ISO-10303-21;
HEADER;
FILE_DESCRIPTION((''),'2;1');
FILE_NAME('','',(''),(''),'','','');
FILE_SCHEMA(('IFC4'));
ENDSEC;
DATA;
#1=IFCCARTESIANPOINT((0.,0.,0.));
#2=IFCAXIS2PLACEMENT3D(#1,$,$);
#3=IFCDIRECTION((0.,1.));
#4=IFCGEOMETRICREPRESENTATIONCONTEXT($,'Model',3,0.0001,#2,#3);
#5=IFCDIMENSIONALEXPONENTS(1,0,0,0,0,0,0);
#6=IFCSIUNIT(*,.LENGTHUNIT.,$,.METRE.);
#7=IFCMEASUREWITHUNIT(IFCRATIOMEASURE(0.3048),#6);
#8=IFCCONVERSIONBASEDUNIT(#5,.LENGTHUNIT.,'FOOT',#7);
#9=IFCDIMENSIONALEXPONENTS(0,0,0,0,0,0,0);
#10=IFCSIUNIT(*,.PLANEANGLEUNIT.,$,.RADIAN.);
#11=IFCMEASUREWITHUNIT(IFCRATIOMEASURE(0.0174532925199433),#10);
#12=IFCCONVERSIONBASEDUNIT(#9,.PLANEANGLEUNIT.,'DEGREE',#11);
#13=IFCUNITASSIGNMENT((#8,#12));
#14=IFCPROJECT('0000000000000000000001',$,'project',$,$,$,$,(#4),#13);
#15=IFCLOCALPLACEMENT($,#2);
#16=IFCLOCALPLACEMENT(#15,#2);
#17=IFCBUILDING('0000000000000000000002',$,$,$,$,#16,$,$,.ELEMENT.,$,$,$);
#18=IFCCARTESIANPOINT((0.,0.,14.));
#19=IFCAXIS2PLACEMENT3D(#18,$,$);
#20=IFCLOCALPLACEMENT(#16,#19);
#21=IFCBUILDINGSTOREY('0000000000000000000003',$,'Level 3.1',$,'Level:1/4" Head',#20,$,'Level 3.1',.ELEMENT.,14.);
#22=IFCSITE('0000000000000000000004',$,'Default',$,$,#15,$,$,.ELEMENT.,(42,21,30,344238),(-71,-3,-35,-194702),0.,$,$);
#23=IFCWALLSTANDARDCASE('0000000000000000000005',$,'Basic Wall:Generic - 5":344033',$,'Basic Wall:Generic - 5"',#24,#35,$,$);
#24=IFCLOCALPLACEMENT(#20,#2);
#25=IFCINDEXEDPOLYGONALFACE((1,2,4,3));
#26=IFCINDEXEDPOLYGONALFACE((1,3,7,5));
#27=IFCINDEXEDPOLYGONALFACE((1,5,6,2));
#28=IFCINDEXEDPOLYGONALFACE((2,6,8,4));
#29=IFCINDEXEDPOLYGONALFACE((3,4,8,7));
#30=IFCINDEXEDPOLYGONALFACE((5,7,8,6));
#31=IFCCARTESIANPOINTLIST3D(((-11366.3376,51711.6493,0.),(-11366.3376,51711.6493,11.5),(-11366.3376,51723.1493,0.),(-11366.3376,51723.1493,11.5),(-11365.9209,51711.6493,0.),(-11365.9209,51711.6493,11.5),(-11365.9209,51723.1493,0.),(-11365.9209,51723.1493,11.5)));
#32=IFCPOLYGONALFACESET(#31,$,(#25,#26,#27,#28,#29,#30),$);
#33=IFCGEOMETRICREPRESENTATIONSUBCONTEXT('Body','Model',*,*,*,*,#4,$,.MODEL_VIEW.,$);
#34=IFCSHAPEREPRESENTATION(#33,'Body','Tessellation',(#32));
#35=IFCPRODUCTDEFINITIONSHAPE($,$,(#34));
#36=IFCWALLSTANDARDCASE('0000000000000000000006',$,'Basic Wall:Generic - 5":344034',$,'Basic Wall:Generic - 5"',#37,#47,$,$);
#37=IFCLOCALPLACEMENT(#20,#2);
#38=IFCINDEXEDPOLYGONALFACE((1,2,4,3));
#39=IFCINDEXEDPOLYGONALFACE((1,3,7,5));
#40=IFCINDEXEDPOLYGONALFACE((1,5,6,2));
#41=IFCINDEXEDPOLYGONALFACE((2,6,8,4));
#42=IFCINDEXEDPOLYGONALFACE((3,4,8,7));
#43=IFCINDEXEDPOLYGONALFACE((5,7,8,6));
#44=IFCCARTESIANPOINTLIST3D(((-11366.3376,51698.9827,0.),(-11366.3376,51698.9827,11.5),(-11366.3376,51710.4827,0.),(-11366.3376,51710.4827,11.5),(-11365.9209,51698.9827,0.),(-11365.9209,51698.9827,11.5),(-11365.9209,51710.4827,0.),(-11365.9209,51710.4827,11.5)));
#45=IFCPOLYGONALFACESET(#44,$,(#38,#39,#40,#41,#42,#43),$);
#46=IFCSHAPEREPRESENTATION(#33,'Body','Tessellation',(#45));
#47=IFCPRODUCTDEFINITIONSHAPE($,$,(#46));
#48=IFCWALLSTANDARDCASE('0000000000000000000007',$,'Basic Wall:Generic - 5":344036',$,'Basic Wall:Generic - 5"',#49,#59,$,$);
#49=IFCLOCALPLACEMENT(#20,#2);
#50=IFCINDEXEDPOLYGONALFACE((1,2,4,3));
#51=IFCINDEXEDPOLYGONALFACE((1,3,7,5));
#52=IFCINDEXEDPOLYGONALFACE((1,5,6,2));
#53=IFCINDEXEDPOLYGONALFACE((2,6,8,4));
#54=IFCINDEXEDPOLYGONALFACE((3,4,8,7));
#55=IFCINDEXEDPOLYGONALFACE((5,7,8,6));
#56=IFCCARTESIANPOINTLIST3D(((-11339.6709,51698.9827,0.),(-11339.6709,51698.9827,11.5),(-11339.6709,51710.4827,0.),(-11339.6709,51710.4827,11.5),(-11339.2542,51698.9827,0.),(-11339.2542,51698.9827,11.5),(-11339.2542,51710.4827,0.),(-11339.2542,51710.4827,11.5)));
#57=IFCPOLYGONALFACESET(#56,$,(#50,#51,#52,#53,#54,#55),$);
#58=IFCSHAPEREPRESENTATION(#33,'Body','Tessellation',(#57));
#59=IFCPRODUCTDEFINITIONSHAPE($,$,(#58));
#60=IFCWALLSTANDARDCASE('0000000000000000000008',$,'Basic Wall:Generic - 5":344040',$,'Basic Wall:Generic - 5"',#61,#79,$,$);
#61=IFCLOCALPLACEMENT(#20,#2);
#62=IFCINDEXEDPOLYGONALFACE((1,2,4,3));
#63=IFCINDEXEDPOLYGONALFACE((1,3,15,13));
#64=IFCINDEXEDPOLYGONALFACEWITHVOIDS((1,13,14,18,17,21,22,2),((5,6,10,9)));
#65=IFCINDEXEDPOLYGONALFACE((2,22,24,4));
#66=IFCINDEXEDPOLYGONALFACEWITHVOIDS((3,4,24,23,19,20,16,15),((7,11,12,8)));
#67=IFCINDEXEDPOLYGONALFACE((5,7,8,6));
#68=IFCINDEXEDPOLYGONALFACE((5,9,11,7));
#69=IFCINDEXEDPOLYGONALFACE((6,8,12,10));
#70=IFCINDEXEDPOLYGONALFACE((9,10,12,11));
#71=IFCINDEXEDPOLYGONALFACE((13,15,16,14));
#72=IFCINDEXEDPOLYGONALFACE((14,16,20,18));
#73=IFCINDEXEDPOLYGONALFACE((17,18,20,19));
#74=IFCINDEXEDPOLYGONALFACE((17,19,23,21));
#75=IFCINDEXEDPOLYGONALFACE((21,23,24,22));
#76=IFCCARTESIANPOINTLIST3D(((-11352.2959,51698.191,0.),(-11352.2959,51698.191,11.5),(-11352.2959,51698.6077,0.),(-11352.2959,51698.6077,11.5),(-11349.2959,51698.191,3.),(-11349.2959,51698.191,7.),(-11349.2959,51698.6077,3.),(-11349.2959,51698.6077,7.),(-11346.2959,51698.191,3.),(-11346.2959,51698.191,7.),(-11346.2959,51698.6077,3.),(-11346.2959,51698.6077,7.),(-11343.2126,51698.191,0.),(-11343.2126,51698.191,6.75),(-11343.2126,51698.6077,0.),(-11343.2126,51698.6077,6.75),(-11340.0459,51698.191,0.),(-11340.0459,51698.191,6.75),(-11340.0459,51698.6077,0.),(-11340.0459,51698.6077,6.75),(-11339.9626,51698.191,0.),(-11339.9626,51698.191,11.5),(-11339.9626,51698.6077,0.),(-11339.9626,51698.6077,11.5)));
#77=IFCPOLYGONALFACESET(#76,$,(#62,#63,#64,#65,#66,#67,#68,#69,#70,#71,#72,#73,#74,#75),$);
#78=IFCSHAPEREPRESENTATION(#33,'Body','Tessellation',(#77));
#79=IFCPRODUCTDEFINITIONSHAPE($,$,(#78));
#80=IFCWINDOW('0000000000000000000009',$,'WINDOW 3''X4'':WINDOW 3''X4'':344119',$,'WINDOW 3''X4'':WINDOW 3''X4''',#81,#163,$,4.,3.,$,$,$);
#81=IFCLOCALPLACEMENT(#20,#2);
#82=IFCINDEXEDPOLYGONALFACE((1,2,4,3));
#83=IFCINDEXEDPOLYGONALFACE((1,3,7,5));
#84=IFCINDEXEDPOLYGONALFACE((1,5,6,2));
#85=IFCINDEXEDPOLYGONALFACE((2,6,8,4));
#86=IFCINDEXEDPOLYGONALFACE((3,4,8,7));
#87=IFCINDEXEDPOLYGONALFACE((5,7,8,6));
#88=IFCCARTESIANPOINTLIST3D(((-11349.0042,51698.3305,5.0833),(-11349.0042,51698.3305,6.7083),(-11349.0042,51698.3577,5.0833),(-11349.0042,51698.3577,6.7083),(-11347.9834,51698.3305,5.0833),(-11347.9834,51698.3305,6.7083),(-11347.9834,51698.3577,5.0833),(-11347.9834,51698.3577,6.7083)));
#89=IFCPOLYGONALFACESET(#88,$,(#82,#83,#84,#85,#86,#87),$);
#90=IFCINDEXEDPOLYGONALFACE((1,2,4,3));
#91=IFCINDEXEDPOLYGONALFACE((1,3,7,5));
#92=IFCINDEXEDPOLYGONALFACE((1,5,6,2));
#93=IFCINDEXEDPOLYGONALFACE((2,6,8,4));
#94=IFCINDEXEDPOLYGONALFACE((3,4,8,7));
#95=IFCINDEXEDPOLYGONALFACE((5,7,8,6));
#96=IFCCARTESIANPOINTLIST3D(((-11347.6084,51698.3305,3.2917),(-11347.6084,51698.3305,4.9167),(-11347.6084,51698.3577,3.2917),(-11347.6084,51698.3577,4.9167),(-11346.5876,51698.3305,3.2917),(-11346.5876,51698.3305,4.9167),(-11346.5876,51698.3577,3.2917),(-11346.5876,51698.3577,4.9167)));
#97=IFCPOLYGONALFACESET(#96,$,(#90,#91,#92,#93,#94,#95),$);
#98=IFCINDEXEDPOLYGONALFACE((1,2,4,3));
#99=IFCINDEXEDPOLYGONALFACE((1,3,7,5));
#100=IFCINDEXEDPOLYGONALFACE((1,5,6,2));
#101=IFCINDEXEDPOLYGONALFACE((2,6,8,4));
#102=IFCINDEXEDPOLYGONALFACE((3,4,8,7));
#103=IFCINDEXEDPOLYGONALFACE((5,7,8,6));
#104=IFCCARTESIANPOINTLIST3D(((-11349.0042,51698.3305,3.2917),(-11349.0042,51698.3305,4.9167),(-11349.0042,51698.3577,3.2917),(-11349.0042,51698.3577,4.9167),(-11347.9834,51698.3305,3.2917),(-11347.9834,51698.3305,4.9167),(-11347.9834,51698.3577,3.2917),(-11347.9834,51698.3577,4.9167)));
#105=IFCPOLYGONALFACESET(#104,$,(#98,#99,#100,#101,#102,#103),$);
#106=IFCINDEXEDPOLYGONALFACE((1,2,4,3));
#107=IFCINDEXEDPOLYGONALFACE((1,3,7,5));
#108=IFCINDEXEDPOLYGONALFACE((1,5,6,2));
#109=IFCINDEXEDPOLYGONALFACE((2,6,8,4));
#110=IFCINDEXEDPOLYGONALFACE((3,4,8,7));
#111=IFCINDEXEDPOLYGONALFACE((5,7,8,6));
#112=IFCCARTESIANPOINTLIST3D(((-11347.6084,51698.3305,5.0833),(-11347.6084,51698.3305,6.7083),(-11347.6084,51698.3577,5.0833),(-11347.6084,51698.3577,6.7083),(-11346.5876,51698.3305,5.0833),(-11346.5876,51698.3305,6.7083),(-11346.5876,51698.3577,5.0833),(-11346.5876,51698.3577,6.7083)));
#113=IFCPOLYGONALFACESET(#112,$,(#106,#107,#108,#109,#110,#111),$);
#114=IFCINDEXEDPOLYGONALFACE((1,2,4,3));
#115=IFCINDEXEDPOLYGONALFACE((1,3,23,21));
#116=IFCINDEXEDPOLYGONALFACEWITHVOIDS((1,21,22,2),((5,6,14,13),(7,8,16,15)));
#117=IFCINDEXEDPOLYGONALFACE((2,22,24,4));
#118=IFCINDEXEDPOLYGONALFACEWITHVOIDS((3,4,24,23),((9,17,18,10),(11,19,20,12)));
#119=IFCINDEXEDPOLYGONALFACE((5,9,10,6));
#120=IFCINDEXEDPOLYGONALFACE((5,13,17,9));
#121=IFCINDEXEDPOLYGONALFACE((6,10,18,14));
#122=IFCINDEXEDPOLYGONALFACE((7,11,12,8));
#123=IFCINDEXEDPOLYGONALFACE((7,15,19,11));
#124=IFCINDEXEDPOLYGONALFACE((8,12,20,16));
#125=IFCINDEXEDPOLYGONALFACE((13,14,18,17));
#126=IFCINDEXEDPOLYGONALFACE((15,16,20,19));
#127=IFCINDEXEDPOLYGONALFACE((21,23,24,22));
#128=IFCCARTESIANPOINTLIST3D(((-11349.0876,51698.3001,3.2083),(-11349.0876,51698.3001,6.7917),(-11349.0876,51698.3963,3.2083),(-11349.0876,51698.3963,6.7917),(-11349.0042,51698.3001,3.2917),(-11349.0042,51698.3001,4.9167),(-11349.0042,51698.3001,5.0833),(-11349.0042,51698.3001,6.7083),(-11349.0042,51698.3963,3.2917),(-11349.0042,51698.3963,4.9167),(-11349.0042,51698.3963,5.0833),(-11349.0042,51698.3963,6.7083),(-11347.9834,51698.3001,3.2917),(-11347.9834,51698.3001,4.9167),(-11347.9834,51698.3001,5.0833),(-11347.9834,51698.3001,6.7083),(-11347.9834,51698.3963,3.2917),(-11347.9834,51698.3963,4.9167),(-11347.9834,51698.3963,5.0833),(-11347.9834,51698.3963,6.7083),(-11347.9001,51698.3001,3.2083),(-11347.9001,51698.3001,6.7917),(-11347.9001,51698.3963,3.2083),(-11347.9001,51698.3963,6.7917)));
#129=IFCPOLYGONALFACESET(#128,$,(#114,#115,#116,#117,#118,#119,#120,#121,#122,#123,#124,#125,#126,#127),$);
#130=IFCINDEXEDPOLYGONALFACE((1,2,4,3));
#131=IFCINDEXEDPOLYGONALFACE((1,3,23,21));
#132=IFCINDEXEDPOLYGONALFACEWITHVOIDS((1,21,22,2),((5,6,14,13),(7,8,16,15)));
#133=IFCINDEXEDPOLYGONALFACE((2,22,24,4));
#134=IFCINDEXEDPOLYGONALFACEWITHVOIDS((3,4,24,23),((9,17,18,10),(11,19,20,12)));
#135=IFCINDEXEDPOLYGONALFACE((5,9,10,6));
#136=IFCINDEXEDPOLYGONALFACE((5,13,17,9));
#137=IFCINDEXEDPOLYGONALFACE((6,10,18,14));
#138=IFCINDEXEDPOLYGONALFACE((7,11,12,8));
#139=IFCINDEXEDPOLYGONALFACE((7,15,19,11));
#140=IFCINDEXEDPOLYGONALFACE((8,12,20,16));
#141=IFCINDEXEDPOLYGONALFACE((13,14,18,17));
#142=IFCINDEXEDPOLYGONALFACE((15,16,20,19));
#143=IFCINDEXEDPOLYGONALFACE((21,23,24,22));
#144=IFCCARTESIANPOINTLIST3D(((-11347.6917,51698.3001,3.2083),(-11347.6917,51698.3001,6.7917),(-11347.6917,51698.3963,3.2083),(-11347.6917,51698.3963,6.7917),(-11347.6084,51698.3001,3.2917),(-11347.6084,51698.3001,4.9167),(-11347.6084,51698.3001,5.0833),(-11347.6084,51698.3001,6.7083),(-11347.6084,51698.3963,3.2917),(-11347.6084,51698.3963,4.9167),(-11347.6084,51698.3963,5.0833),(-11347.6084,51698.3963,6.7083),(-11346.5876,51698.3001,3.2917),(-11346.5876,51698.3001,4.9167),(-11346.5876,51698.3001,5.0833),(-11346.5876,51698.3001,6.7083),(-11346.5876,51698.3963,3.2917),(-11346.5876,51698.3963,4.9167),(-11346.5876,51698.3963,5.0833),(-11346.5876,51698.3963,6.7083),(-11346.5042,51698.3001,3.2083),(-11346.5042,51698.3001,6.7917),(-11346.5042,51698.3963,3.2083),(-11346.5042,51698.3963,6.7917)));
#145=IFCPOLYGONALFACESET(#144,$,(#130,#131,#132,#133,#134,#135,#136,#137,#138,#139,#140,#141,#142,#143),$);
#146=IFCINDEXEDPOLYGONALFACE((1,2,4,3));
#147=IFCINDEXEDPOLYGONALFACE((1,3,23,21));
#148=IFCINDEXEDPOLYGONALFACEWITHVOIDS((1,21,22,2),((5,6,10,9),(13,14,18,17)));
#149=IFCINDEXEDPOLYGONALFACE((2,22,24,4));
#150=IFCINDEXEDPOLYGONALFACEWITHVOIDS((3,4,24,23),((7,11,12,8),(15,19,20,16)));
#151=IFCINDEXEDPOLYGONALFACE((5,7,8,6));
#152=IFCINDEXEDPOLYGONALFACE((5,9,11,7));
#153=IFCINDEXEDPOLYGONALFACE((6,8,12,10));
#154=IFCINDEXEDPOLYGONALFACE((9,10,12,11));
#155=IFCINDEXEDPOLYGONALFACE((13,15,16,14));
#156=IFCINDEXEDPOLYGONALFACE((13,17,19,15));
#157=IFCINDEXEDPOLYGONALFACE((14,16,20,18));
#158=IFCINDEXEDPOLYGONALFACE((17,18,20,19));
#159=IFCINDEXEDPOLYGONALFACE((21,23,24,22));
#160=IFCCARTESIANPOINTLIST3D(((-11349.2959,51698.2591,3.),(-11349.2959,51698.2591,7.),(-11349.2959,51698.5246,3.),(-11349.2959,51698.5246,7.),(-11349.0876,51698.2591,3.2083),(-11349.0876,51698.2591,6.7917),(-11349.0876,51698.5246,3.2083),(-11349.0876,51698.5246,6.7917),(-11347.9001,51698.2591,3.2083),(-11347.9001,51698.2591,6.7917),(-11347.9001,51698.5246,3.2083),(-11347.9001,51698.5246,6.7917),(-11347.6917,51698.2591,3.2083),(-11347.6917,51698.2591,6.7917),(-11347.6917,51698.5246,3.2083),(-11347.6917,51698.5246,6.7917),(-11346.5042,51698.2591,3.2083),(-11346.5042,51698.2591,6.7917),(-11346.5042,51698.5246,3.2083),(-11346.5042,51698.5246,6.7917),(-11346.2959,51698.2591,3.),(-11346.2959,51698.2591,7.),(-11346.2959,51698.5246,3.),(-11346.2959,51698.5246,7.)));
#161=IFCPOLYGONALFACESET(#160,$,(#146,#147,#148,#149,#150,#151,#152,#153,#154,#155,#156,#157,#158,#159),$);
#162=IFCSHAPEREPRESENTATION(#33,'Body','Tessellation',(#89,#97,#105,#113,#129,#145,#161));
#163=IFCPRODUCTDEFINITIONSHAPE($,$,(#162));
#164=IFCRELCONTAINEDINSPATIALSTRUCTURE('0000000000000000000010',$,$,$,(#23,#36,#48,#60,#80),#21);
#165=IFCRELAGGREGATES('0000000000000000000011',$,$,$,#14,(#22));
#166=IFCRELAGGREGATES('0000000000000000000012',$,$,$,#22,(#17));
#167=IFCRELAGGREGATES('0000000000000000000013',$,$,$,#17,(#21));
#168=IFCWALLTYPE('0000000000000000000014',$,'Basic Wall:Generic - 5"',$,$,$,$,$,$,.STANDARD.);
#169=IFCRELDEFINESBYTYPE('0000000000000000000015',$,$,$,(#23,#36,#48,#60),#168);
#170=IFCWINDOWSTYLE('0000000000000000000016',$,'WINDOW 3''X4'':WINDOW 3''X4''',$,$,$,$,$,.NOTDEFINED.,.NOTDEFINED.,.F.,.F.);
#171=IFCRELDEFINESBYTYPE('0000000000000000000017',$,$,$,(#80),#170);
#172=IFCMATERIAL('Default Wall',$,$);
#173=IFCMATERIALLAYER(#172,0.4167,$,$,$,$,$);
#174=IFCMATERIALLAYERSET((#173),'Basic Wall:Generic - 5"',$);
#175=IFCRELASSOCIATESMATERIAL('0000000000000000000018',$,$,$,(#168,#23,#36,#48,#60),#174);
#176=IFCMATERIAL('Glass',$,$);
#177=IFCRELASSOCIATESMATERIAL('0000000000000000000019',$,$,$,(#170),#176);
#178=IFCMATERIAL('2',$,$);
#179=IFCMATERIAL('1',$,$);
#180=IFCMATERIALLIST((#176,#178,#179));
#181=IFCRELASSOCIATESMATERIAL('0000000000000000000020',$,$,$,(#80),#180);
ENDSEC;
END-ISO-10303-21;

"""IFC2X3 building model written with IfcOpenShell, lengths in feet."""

from ifc_helpers import new_model, entity, si_unit, converted_unit, direction, frame, frame_2d, origin, origin_2d_with_axis, place, context, subcontext, project, spatial, polyline, rectangle, outline, extrude, source, transform, mapped, material, material_list, layer, layer_set, layer_usage, type_object, type_shapes, element, fill, save


model = new_model("IFC2X3")

# Units and contexts
model_context = context("Model", 3, precision=0.0001, world=origin(), true_north=direction((0.0, 1.0)))
body_context = subcontext(model_context, "Body", "Model", "MODEL_VIEW")
ifc_project = project(units=[converted_unit("LENGTHUNIT", "FOOT", entity("IfcRatioMeasure", 0.3048), si_unit("LENGTHUNIT", "METRE"), dimensions=[1, 0, 0, 0, 0, 0, 0]), converted_unit("PLANEANGLEUNIT", "DEGREE", entity("IfcRatioMeasure", 0.0174532925199433), si_unit("PLANEANGLEUNIT", "RADIAN"), dimensions=[0, 0, 0, 0, 0, 0, 0])], contexts=[model_context])

# Site, building, storey
site_placement = place(None, origin())
site = spatial("IfcSite", under=ifc_project, at=site_placement, Name="Default", CompositionType="ELEMENT", RefLatitude=(42, 21, 30, 344238), RefLongitude=(-71, -3, -35, -194702), RefElevation=0.0)
building_placement = place(site_placement, origin())
building = spatial("IfcBuilding", under=site, at=building_placement, CompositionType="ELEMENT")
storey_placement = place(building_placement, frame((0.0, 0.0, 14.0)))
storey = spatial("IfcBuildingStorey", under=building, at=storey_placement, Name="Level 3.1", ObjectType="Level:1/4\" Head", LongName="Level 3.1", CompositionType="ELEMENT", Elevation=14.0)

# Shared definitions
ifc_material_1 = material(Name="Default Wall")
ifc_material_2 = material(Name="Glass")
ifc_material_3 = material(Name="2")
ifc_material_4 = material(Name="1")
ifc_layer_1 = layer(ifc_material_1, 0.4167)
ifc_layer_set_1 = layer_set([ifc_layer_1], Name="Basic Wall:Generic - 5\"")
wall_type_1 = type_object("IfcWallType", Name="Basic Wall:Generic - 5\"", PredefinedType="STANDARD", material=ifc_layer_set_1)

# Walls
ifc_layer_usage_1 = layer_usage(ifc_layer_set_1, "AXIS2", "NEGATIVE", 0.2083)
wall_1_placement = place(storey_placement, frame((-11366.1292, 51723.1493, 0.0), z_axis=(0.0, 0.0, 1.0), x_axis=(0.0, -1.0, 0.0)))
element("IfcWallStandardCase", 1, at=wall_1_placement, inside=storey, type_object=wall_type_1, material=ifc_layer_usage_1, Name="Basic Wall:Generic - 5\":344033", ObjectType="Basic Wall:Generic - 5\"", context=body_context, shape_type="SweptSolid", body=[
    extrude(rectangle(XDim=11.5, YDim=0.4167, at=frame_2d((5.75, 0.0), x_axis=(-1.0, 0.0))), origin(), (0.0, 0.0, 1.0), 11.5),
])
ifc_layer_usage_2 = layer_usage(ifc_layer_set_1, "AXIS2", "NEGATIVE", 0.2083)
wall_2_placement = place(storey_placement, frame((-11366.1292, 51710.4827, 0.0), z_axis=(0.0, 0.0, 1.0), x_axis=(0.0, -1.0, 0.0)))
element("IfcWallStandardCase", 2, at=wall_2_placement, inside=storey, type_object=wall_type_1, material=ifc_layer_usage_2, Name="Basic Wall:Generic - 5\":344034", ObjectType="Basic Wall:Generic - 5\"", context=body_context, shape_type="SweptSolid", body=[
    extrude(rectangle(XDim=11.5, YDim=0.4167, at=frame_2d((5.75, 0.0), x_axis=(-1.0, 0.0))), origin(), (0.0, 0.0, 1.0), 11.5),
])
ifc_layer_usage_3 = layer_usage(ifc_layer_set_1, "AXIS2", "NEGATIVE", 0.2083)
wall_3_placement = place(storey_placement, frame((-11339.4626, 51710.4827, 0.0), z_axis=(0.0, 0.0, 1.0), x_axis=(0.0, -1.0, 0.0)))
element("IfcWallStandardCase", 3, at=wall_3_placement, inside=storey, type_object=wall_type_1, material=ifc_layer_usage_3, Name="Basic Wall:Generic - 5\":344036", ObjectType="Basic Wall:Generic - 5\"", context=body_context, shape_type="SweptSolid", body=[
    extrude(rectangle(XDim=11.5, YDim=0.4167, at=frame_2d((5.75, 0.0), x_axis=(-1.0, 0.0))), origin(), (0.0, 0.0, 1.0), 11.5),
])

# Wall, openings, window
ifc_layer_usage_4 = layer_usage(ifc_layer_set_1, "AXIS2", "NEGATIVE", 0.2083)
wall_4_placement = place(storey_placement, frame((-11352.2959, 51698.3993, 0.0)))
wall_4 = element("IfcWallStandardCase", 4, at=wall_4_placement, inside=storey, type_object=wall_type_1, material=ifc_layer_usage_4, Name="Basic Wall:Generic - 5\":344040", ObjectType="Basic Wall:Generic - 5\"", context=body_context, shape_type="SweptSolid", body=[
    extrude(rectangle(XDim=12.3333, YDim=0.4167, at=frame_2d((6.1667, 0.0), x_axis=(-1.0, 0.0))), origin(), (0.0, 0.0, 1.0), 11.5),
])
opening_1_placement = place(wall_4_placement, frame((9.0833, -0.2083, 0.0)))
element("IfcOpeningElement", 5, at=opening_1_placement, cuts=wall_4, ObjectType="Opening", context=body_context, shape_type="SweptSolid", body=[
    extrude(rectangle(XDim=6.75, YDim=3.1667, at=frame_2d((3.375, 1.5833), x_axis=(1.0, 0.0))), frame((0.0, 0.0, 0.0), z_axis=(0.0, 1.0, 0.0), x_axis=(0.0, 0.0, 1.0)), (0.0, 0.0, 1.0), 0.4167),
])
opening_2_placement = place(wall_4_placement, frame((6.0, 0.2083, 3.0)))
opening_2 = element("IfcOpeningElement", 6, at=opening_2_placement, cuts=wall_4, ObjectType="Opening", context=body_context, shape_type="SweptSolid", body=[
    extrude(rectangle(XDim=4.0, YDim=3.0, at=frame_2d((2.0, 1.5), x_axis=(-1.0, 0.0))), frame((0.0, 0.0, 0.0), z_axis=(0.0, -1.0, 0.0), x_axis=(0.0, 0.0, 1.0)), (0.0, 0.0, 1.0), 0.4167),
])
ifc_material_list_1 = material_list([ifc_material_2, ifc_material_3, ifc_material_4])
window_style_1 = type_object("IfcWindowStyle", Name="WINDOW 3'X4':WINDOW 3'X4'", ConstructionType="NOTDEFINED", OperationType="NOTDEFINED", ParameterTakesPrecedence=False, Sizeable=False, material=ifc_material_2)
shared_shape_1 = source(origin(), body_context, "Body", "SweptSolid", [
    extrude(rectangle(XDim=0.0272, YDim=1.0208, at=origin_2d_with_axis()), frame((2.1979, 0.2636, 2.0833), z_axis=(0.0, 0.0, 1.0), x_axis=(0.0, 1.0, 0.0)), (0.0, 0.0, 1.0), 1.625),
    extrude(rectangle(XDim=0.0272, YDim=1.0208, at=origin_2d_with_axis()), frame((0.8021, 0.2636, 0.2917), z_axis=(0.0, 0.0, 1.0), x_axis=(0.0, 1.0, 0.0)), (0.0, 0.0, 1.0), 1.625),
    extrude(rectangle(XDim=0.0272, YDim=1.0208, at=origin_2d_with_axis()), frame((2.1979, 0.2636, 0.2917), z_axis=(0.0, 0.0, 1.0), x_axis=(0.0, 1.0, 0.0)), (0.0, 0.0, 1.0), 1.625),
    extrude(rectangle(XDim=0.0272, YDim=1.0208, at=origin_2d_with_axis()), frame((0.8021, 0.2636, 2.0833), z_axis=(0.0, 0.0, 1.0), x_axis=(0.0, 1.0, 0.0)), (0.0, 0.0, 1.0), 1.625),
    extrude(outline(polyline([(-0.5938, -1.7917), (0.5938, -1.7917), (0.5938, 1.7917), (-0.5938, 1.7917), (-0.5938, -1.7917)]), holes=[polyline([(-0.5104, -0.0833), (0.5104, -0.0833), (0.5104, -1.7083), (-0.5104, -1.7083), (-0.5104, -0.0833)]), polyline([(-0.5104, 1.7083), (0.5104, 1.7083), (0.5104, 0.0833), (-0.5104, 0.0833), (-0.5104, 1.7083)])]), frame((2.1979, 0.2114, 2.0), z_axis=(0.0, 1.0, 0.0), x_axis=(-1.0, 0.0, 0.0)), (0.0, 0.0, 1.0), 0.0962),
    extrude(outline(polyline([(-1.7917, -0.5937), (1.7917, -0.5937), (1.7917, 0.5937), (-1.7917, 0.5937), (-1.7917, -0.5937)]), holes=[polyline([(0.0833, -0.5104), (0.0833, 0.5104), (1.7083, 0.5104), (1.7083, -0.5104), (0.0833, -0.5104)]), polyline([(-1.7083, -0.5104), (-1.7083, 0.5104), (-0.0833, 0.5104), (-0.0833, -0.5104), (-1.7083, -0.5104)])]), frame((0.8021, 0.2114, 2.0), z_axis=(0.0, 1.0, 0.0), x_axis=(0.0, 0.0, -1.0)), (0.0, 0.0, 1.0), 0.0962),
    extrude(outline(polyline([(-1.5, -2.0), (1.5, -2.0), (1.5, 2.0), (-1.5, 2.0), (-1.5, -2.0)]), holes=[polyline([(-0.1042, 1.7917), (-0.1042, -1.7917), (-1.2917, -1.7917), (-1.2917, 1.7917), (-0.1042, 1.7917)]), polyline([(0.1042, -1.7917), (0.1042, 1.7917), (1.2917, 1.7917), (1.2917, -1.7917), (0.1042, -1.7917)])]), frame((1.5, 0.0831, 2.0), z_axis=(0.0, 1.0, 0.0), x_axis=(1.0, 0.0, 0.0)), (0.0, 0.0, 1.0), 0.2655),
])
type_shapes(window_style_1, [shared_shape_1])
window_1_placement = place(opening_2_placement, frame((0.0, 0.0, 0.0), z_axis=(0.0, 0.0, 1.0), x_axis=(-1.0, 0.0, 0.0)))
window_1 = element("IfcWindow", 7, at=window_1_placement, inside=storey, type_object=window_style_1, material=ifc_material_list_1, Name="WINDOW 3'X4':WINDOW 3'X4':344119", ObjectType="WINDOW 3'X4':WINDOW 3'X4'", OverallHeight=4.0, OverallWidth=3.0, context=body_context, shape_type="MappedRepresentation", body=[
    mapped(shared_shape_1, transform((0.0, 0.0, 0.0), scale=1.0)),
])
fill(opening_2, window_1)

save(model, "model.ifc")
